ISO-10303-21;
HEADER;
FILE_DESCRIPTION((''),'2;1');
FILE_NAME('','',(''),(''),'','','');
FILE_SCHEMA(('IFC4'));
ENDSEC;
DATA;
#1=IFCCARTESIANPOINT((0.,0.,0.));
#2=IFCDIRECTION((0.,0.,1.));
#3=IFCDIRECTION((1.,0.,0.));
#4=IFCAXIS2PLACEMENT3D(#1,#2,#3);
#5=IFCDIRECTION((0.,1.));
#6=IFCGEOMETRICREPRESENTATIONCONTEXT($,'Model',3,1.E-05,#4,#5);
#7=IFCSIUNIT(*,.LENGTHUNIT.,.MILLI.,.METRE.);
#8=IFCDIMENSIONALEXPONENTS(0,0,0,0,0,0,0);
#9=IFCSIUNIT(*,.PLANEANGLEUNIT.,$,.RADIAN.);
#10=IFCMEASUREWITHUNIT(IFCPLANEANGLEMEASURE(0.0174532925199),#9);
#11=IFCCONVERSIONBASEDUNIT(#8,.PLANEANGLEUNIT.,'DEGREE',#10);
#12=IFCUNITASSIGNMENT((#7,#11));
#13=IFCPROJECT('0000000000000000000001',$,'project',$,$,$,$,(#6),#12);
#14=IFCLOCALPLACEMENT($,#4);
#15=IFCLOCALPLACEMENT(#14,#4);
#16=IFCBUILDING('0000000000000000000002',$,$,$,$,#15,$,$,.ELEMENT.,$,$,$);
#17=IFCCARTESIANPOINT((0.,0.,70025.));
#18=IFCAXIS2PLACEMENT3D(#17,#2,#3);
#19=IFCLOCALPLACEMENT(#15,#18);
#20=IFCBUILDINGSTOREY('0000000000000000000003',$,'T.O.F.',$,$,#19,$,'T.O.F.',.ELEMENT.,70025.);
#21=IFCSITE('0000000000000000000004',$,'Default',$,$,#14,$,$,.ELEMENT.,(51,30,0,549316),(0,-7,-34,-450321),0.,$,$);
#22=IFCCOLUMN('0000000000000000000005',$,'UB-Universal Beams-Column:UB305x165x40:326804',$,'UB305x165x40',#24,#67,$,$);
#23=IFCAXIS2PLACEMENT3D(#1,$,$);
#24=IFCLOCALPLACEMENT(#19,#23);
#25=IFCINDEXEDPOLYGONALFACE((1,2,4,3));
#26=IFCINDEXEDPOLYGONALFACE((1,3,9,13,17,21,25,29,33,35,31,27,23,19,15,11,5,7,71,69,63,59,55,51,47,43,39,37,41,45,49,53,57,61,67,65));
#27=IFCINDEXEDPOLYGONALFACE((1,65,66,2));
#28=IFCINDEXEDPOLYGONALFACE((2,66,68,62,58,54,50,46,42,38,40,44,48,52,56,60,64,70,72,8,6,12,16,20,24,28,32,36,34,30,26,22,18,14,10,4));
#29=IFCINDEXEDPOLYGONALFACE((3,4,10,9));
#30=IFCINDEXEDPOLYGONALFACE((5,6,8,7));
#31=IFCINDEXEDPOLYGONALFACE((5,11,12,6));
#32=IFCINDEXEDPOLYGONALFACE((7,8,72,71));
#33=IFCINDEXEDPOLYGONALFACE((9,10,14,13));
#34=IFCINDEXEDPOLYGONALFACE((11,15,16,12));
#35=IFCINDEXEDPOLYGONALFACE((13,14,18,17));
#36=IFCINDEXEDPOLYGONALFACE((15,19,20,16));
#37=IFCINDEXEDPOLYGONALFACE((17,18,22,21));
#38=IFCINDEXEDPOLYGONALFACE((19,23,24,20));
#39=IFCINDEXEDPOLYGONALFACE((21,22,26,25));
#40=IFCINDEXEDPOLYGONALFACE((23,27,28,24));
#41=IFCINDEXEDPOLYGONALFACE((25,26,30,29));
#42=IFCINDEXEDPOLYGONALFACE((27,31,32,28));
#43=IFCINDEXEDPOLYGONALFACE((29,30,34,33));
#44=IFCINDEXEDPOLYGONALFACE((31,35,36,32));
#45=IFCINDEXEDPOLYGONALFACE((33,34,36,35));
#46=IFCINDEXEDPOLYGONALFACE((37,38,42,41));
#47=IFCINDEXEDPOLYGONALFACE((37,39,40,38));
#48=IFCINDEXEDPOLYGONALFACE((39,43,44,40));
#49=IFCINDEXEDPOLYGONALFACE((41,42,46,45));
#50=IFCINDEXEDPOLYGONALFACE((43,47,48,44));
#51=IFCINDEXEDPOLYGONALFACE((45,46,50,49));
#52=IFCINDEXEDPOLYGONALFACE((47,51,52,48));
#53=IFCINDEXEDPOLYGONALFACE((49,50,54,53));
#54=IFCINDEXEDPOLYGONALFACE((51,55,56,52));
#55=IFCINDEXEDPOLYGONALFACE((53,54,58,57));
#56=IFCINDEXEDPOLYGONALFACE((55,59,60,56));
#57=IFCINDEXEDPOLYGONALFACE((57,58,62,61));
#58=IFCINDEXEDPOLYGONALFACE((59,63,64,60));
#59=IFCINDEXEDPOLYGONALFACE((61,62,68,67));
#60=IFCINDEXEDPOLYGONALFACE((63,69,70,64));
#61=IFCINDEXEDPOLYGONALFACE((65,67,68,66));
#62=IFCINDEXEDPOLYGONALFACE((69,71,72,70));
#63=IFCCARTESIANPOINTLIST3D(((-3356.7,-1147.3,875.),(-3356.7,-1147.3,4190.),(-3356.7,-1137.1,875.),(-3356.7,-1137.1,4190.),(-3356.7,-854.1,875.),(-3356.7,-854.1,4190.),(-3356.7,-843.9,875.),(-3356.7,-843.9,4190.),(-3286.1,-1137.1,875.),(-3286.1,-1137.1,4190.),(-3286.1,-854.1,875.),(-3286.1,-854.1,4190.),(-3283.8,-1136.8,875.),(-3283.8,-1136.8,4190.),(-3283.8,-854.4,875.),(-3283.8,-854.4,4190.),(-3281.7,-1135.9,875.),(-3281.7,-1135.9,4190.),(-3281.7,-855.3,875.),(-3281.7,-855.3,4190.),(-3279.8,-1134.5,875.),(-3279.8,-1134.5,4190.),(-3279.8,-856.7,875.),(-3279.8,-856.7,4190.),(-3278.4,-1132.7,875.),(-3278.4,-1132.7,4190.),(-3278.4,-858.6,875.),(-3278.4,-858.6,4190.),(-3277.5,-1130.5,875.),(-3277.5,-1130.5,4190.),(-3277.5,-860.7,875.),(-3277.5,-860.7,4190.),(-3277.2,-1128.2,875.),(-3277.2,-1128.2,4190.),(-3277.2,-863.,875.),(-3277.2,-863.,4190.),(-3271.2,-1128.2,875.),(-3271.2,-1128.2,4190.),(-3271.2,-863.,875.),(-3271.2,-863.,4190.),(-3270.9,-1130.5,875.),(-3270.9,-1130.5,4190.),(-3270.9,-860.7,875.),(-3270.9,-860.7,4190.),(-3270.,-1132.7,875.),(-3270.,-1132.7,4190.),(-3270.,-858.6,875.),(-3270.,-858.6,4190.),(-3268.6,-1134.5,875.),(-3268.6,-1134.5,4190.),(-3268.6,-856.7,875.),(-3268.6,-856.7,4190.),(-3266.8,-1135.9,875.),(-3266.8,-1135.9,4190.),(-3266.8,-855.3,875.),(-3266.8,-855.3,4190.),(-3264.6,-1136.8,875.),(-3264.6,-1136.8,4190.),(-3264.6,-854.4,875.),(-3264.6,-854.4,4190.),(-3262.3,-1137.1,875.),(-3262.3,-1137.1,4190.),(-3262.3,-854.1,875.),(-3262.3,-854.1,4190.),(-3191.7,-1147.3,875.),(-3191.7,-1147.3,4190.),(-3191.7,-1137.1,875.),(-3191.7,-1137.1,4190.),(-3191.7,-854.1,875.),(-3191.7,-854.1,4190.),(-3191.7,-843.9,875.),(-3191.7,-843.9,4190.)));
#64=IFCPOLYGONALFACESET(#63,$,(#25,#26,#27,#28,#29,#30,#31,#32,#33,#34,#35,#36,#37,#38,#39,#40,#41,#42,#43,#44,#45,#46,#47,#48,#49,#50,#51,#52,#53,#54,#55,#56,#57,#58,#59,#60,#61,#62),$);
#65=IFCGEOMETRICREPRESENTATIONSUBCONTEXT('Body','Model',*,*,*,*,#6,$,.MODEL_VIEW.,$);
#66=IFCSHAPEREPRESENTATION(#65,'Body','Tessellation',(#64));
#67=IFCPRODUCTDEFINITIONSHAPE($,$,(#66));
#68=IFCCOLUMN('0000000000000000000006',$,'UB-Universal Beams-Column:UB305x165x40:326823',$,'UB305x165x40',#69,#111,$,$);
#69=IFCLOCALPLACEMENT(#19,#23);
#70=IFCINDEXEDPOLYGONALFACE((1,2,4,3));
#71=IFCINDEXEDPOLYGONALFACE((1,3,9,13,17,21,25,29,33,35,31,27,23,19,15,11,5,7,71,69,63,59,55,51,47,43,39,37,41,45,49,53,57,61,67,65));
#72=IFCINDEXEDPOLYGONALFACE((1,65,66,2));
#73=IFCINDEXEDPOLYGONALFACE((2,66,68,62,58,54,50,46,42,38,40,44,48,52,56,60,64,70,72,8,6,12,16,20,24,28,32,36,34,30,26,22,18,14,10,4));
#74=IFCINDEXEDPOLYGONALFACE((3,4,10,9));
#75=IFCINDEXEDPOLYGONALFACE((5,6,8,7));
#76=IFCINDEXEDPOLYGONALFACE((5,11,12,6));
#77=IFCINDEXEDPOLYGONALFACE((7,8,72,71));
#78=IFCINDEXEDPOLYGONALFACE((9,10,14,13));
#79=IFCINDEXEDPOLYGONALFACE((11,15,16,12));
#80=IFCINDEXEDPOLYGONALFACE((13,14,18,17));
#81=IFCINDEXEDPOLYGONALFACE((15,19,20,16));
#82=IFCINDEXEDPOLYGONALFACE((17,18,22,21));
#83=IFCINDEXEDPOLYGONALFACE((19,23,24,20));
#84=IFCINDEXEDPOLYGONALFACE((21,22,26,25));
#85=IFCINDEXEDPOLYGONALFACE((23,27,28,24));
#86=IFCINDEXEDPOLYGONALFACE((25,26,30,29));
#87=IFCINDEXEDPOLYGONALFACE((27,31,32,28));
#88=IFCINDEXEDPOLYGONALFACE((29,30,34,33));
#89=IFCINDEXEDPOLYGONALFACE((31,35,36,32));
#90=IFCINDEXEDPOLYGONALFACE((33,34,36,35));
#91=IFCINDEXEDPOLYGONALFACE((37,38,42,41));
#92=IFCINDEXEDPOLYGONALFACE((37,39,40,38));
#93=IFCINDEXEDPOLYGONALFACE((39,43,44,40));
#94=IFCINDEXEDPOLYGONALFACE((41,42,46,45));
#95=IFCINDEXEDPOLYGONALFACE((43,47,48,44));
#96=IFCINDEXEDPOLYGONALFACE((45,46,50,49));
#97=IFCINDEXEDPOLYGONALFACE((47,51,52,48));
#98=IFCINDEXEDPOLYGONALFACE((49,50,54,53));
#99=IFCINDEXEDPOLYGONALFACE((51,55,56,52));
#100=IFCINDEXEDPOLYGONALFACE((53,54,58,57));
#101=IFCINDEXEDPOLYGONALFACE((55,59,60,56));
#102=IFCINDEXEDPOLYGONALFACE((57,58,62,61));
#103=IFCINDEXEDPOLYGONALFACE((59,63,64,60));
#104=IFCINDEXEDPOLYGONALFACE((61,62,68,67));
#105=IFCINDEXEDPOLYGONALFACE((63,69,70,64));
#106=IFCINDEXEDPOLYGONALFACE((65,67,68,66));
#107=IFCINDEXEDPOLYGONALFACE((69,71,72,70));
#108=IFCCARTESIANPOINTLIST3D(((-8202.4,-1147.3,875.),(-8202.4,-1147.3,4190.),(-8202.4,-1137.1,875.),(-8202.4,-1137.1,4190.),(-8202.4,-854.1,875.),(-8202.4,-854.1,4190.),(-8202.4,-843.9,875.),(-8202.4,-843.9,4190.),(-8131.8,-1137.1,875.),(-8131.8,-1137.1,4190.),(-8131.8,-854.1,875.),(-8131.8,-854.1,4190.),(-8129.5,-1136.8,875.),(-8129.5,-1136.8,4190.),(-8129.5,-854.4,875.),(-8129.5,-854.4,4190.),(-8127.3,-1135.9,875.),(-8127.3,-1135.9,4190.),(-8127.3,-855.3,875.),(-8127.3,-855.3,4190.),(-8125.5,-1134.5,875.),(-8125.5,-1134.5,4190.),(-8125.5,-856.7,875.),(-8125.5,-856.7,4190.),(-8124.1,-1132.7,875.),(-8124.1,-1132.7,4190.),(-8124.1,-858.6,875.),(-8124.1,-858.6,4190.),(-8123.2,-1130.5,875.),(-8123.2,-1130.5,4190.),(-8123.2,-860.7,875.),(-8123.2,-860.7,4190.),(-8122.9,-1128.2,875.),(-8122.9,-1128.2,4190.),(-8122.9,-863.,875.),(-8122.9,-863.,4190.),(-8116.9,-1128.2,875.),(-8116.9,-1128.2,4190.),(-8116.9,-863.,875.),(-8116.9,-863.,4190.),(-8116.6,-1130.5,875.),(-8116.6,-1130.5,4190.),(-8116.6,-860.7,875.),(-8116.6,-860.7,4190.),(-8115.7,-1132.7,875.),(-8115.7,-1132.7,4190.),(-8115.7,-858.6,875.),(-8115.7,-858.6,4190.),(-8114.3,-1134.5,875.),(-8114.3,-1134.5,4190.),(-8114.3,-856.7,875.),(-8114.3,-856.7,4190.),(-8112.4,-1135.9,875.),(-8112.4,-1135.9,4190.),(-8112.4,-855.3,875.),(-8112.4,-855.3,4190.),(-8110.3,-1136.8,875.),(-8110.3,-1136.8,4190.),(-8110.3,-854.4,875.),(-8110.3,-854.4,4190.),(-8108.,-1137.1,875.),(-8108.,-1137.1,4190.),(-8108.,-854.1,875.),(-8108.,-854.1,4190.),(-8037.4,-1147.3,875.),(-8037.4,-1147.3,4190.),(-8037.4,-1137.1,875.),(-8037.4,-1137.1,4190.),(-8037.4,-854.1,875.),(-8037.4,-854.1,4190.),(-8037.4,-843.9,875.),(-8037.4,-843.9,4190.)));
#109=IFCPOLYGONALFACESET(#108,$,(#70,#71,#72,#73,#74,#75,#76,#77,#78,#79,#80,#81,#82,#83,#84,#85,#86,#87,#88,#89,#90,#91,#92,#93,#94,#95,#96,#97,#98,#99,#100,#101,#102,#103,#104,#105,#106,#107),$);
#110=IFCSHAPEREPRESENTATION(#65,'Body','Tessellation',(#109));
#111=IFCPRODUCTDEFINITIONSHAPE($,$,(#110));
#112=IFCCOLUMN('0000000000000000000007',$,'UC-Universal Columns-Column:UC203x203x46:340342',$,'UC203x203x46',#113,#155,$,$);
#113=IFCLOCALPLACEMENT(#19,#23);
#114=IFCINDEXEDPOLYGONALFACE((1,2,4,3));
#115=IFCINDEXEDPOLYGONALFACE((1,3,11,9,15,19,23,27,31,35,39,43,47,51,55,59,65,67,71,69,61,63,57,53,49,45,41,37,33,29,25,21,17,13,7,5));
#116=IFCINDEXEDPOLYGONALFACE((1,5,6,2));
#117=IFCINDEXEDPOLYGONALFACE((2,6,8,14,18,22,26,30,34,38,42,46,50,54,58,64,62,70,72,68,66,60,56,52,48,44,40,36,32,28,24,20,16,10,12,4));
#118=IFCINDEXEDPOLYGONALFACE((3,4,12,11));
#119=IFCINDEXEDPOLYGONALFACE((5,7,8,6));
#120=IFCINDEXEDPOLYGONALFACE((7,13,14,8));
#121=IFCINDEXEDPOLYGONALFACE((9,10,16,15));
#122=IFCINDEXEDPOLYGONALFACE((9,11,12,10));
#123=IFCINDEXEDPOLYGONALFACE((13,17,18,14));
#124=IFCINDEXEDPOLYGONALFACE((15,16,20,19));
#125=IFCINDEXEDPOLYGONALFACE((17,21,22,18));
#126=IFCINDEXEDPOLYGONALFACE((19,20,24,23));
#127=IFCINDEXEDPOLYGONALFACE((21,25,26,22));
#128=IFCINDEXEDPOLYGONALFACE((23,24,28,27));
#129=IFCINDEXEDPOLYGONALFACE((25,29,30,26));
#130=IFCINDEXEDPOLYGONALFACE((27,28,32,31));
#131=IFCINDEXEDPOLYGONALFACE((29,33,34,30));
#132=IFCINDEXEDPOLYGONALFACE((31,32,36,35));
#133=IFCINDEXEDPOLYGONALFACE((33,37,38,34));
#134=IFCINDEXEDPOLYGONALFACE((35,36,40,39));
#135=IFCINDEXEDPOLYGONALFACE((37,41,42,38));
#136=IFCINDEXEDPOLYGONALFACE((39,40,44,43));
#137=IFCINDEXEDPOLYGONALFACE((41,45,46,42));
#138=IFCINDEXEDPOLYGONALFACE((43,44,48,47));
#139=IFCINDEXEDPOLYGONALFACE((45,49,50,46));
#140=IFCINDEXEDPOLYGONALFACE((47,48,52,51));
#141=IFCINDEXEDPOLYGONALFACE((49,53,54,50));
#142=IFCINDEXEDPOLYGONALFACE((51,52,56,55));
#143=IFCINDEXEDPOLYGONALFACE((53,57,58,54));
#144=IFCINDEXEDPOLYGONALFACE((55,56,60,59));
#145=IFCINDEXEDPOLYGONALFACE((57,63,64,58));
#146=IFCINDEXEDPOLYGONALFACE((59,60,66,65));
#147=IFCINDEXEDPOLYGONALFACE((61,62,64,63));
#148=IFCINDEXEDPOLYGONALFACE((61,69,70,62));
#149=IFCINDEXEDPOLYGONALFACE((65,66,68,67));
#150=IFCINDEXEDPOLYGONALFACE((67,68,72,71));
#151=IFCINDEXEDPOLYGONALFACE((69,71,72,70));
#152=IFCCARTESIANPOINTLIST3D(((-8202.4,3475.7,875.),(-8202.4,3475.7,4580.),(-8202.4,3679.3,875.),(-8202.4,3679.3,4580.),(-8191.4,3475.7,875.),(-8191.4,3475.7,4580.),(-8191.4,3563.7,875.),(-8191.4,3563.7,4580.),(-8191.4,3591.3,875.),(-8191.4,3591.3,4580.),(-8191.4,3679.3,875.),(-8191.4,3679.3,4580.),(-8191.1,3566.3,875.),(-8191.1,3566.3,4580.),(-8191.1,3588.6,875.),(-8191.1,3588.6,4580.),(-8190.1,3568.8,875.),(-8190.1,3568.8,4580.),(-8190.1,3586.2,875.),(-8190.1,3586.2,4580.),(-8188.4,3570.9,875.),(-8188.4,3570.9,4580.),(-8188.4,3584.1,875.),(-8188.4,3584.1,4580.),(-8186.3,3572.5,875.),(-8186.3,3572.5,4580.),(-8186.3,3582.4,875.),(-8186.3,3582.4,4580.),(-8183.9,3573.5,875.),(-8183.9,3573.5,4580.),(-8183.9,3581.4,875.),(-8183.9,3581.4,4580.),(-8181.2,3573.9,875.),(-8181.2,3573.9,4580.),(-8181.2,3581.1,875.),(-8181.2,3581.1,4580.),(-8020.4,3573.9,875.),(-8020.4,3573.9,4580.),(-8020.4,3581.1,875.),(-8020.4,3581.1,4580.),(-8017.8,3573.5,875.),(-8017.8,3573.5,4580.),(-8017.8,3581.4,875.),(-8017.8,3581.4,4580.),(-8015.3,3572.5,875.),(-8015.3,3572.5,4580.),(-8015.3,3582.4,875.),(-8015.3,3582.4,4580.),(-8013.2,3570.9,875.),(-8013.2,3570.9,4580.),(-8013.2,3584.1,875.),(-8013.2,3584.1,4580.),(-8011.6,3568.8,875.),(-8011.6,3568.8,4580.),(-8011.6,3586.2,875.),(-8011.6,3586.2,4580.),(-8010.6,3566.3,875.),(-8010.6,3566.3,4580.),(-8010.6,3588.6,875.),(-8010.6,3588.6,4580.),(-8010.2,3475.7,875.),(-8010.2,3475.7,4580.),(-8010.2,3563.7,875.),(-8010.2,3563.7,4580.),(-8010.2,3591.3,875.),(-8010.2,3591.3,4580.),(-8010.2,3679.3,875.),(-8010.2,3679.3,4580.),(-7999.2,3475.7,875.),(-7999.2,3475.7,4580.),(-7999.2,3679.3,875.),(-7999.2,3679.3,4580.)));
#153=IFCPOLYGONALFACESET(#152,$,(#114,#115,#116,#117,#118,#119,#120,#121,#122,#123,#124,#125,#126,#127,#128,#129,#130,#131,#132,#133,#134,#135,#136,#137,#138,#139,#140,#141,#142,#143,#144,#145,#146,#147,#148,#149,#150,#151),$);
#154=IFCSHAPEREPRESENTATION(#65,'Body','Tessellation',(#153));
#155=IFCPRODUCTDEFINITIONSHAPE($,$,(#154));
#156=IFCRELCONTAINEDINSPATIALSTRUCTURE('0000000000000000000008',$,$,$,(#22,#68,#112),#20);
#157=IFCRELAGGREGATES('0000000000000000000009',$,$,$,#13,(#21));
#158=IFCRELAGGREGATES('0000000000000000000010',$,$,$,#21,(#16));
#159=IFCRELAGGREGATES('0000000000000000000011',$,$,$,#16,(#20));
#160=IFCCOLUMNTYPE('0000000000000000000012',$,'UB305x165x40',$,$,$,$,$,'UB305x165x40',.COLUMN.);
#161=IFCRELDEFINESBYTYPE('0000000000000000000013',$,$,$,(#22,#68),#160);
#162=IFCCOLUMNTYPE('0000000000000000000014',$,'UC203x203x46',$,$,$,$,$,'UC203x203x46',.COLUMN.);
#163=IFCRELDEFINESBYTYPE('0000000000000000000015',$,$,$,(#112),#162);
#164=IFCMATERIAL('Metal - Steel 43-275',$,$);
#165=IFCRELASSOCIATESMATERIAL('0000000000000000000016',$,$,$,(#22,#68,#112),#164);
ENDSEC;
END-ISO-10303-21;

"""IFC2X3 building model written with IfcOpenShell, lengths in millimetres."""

from ifc_helpers import new_model, entity, si_unit, converted_unit, point, direction, frame, frame_2d, origin_with_axes, place, context, subcontext, project, spatial, polyline, circle_curve, parameter, trimmed, segment, composite_curve, outline, extrude, material, type_object, element, save


model = new_model("IFC2X3")

# Units and contexts
model_context = context("Model", 3, precision=1e-05, world=origin_with_axes(), true_north=direction((0.0, 1.0)))
body_context = subcontext(model_context, "Body", "Model", "MODEL_VIEW")
ifc_project = project(units=[si_unit("LENGTHUNIT", "METRE", prefix="MILLI"), converted_unit("PLANEANGLEUNIT", "DEGREE", entity("IfcPlaneAngleMeasure", 0.0174532925199), si_unit("PLANEANGLEUNIT", "RADIAN"), dimensions=[0, 0, 0, 0, 0, 0, 0])], contexts=[model_context])

# Site, building, storey
site_placement = place(None, origin_with_axes())
site = spatial("IfcSite", under=ifc_project, at=site_placement, Name="Default", CompositionType="ELEMENT", RefLatitude=(51, 30, 0, 549316), RefLongitude=(0, -7, -34, -450321), RefElevation=0.0)
building_placement = place(site_placement, origin_with_axes())
building = spatial("IfcBuilding", under=site, at=building_placement, CompositionType="ELEMENT")
storey_placement = place(building_placement, frame((0.0, 0.0, 70025.0), z_axis=(0.0, 0.0, 1.0), x_axis=(1.0, 0.0, 0.0)))
storey = spatial("IfcBuildingStorey", under=building, at=storey_placement, Name="T.O.F.", LongName="T.O.F.", CompositionType="ELEMENT", Elevation=70025.0)

# Columns
ifc_material_1 = material(Name="Metal - Steel 43-275")
column_type_1 = type_object("IfcColumnType", Name="UB305x165x40", ElementType="UB305x165x40", PredefinedType="COLUMN")
for number, where, z_axis, x_axis, name in (
    (1, (-3274.2, -995.6, 875.0), (0.0, 0.0, 1.0), (0.0, -1.0, 0.0), "UB-Universal Beams-Column:UB305x165x40:326804"),
    (2, (-8119.9, -995.6, 875.0), (0.0, 0.0, 1.0), (0.0, -1.0, 0.0), "UB-Universal Beams-Column:UB305x165x40:326823"),
):
    element("IfcColumn", number, at=place(storey_placement, frame(where, z_axis=z_axis, x_axis=x_axis)), inside=storey, type_object=column_type_1, material=ifc_material_1, Name=name, ObjectType="UB305x165x40", context=body_context, shape_type="SweptSolid", body=[
        extrude(outline(composite_curve([segment(polyline([(141.5, -82.5), (151.7, -82.5), (151.7, 82.5), (141.5, 82.5), (141.5, 11.9)]), True, "CONTINUOUS"), segment(trimmed(circle_curve(frame_2d((132.6, 11.9), x_axis=(0.0, -1.0)), 8.9), [point((141.5, 11.9)), parameter(90.0)], [point((132.6, 3.0)), parameter(0.0)], False, "CARTESIAN"), True, "CONTINUOUS"), segment(polyline([(132.6, 3.0), (-132.6, 3.0)]), True, "CONTINUOUS"), segment(trimmed(circle_curve(frame_2d((-132.6, 11.9), x_axis=(-1.0, 0.0)), 8.9), [point((-132.6, 3.0)), parameter(90.0)], [point((-141.5, 11.9)), parameter(0.0)], False, "CARTESIAN"), True, "CONTINUOUS"), segment(polyline([(-141.5, 11.9), (-141.5, 82.5), (-151.7, 82.5), (-151.7, -82.5), (-141.5, -82.5), (-141.5, -11.9)]), True, "CONTINUOUS"), segment(trimmed(circle_curve(frame_2d((-132.6, -11.9), x_axis=(0.0, 1.0)), 8.9), [point((-141.5, -11.9)), parameter(90.0)], [point((-132.6, -3.0)), parameter(0.0)], False, "CARTESIAN"), True, "CONTINUOUS"), segment(polyline([(-132.6, -3.0), (132.6, -3.0)]), True, "CONTINUOUS"), segment(trimmed(circle_curve(frame_2d((132.6, -11.9), x_axis=(1.0, 0.0)), 8.9), [point((132.6, -3.0)), parameter(90.0)], [point((141.5, -11.9)), parameter(0.0)], False, "CARTESIAN"), True, "CONTINUOUS"), segment(polyline([(141.5, -11.9), (141.5, -82.5)]), True, "CONTINUOUS")], self_intersect=False)), origin_with_axes(), (0.0, 0.0, 1.0), 3315.0),
    ])
column_type_2 = type_object("IfcColumnType", Name="UC203x203x46", ElementType="UC203x203x46", PredefinedType="COLUMN")
column_1_placement = place(storey_placement, frame((-8100.8, 3577.5, 875.0), z_axis=(0.0, 0.0, 1.0), x_axis=(-1.0, 0.0, 0.0)))
element("IfcColumn", 3, at=column_1_placement, inside=storey, type_object=column_type_2, material=ifc_material_1, Name="UC-Universal Columns-Column:UC203x203x46:340342", ObjectType="UC203x203x46", context=body_context, shape_type="SweptSolid", body=[
    extrude(outline(composite_curve([segment(polyline([(90.6, -101.8), (101.6, -101.8), (101.6, 101.8), (90.6, 101.8), (90.6, 13.8)]), True, "CONTINUOUS"), segment(trimmed(circle_curve(frame_2d((80.4, 13.8), x_axis=(0.0, -1.0)), 10.2), [point((90.6, 13.8)), parameter(90.0)], [point((80.4, 3.6)), parameter(0.0)], False, "CARTESIAN"), True, "CONTINUOUS"), segment(polyline([(80.4, 3.6), (-80.4, 3.6)]), True, "CONTINUOUS"), segment(trimmed(circle_curve(frame_2d((-80.4, 13.8), x_axis=(-1.0, 0.0)), 10.2), [point((-80.4, 3.6)), parameter(90.0)], [point((-90.6, 13.8)), parameter(0.0)], False, "CARTESIAN"), True, "CONTINUOUS"), segment(polyline([(-90.6, 13.8), (-90.6, 101.8), (-101.6, 101.8), (-101.6, -101.8), (-90.6, -101.8), (-90.6, -13.8)]), True, "CONTINUOUS"), segment(trimmed(circle_curve(frame_2d((-80.4, -13.8), x_axis=(0.0, 1.0)), 10.2), [point((-90.6, -13.8)), parameter(90.0)], [point((-80.4, -3.6)), parameter(0.0)], False, "CARTESIAN"), True, "CONTINUOUS"), segment(polyline([(-80.4, -3.6), (80.4, -3.6)]), True, "CONTINUOUS"), segment(trimmed(circle_curve(frame_2d((80.4, -13.8), x_axis=(1.0, 0.0)), 10.2), [point((80.4, -3.6)), parameter(90.0)], [point((90.6, -13.8)), parameter(0.0)], False, "CARTESIAN"), True, "CONTINUOUS"), segment(polyline([(90.6, -13.8), (90.6, -101.8)]), True, "CONTINUOUS")], self_intersect=False)), origin_with_axes(), (0.0, 0.0, 1.0), 3705.0),
])

save(model, "model.ifc")
